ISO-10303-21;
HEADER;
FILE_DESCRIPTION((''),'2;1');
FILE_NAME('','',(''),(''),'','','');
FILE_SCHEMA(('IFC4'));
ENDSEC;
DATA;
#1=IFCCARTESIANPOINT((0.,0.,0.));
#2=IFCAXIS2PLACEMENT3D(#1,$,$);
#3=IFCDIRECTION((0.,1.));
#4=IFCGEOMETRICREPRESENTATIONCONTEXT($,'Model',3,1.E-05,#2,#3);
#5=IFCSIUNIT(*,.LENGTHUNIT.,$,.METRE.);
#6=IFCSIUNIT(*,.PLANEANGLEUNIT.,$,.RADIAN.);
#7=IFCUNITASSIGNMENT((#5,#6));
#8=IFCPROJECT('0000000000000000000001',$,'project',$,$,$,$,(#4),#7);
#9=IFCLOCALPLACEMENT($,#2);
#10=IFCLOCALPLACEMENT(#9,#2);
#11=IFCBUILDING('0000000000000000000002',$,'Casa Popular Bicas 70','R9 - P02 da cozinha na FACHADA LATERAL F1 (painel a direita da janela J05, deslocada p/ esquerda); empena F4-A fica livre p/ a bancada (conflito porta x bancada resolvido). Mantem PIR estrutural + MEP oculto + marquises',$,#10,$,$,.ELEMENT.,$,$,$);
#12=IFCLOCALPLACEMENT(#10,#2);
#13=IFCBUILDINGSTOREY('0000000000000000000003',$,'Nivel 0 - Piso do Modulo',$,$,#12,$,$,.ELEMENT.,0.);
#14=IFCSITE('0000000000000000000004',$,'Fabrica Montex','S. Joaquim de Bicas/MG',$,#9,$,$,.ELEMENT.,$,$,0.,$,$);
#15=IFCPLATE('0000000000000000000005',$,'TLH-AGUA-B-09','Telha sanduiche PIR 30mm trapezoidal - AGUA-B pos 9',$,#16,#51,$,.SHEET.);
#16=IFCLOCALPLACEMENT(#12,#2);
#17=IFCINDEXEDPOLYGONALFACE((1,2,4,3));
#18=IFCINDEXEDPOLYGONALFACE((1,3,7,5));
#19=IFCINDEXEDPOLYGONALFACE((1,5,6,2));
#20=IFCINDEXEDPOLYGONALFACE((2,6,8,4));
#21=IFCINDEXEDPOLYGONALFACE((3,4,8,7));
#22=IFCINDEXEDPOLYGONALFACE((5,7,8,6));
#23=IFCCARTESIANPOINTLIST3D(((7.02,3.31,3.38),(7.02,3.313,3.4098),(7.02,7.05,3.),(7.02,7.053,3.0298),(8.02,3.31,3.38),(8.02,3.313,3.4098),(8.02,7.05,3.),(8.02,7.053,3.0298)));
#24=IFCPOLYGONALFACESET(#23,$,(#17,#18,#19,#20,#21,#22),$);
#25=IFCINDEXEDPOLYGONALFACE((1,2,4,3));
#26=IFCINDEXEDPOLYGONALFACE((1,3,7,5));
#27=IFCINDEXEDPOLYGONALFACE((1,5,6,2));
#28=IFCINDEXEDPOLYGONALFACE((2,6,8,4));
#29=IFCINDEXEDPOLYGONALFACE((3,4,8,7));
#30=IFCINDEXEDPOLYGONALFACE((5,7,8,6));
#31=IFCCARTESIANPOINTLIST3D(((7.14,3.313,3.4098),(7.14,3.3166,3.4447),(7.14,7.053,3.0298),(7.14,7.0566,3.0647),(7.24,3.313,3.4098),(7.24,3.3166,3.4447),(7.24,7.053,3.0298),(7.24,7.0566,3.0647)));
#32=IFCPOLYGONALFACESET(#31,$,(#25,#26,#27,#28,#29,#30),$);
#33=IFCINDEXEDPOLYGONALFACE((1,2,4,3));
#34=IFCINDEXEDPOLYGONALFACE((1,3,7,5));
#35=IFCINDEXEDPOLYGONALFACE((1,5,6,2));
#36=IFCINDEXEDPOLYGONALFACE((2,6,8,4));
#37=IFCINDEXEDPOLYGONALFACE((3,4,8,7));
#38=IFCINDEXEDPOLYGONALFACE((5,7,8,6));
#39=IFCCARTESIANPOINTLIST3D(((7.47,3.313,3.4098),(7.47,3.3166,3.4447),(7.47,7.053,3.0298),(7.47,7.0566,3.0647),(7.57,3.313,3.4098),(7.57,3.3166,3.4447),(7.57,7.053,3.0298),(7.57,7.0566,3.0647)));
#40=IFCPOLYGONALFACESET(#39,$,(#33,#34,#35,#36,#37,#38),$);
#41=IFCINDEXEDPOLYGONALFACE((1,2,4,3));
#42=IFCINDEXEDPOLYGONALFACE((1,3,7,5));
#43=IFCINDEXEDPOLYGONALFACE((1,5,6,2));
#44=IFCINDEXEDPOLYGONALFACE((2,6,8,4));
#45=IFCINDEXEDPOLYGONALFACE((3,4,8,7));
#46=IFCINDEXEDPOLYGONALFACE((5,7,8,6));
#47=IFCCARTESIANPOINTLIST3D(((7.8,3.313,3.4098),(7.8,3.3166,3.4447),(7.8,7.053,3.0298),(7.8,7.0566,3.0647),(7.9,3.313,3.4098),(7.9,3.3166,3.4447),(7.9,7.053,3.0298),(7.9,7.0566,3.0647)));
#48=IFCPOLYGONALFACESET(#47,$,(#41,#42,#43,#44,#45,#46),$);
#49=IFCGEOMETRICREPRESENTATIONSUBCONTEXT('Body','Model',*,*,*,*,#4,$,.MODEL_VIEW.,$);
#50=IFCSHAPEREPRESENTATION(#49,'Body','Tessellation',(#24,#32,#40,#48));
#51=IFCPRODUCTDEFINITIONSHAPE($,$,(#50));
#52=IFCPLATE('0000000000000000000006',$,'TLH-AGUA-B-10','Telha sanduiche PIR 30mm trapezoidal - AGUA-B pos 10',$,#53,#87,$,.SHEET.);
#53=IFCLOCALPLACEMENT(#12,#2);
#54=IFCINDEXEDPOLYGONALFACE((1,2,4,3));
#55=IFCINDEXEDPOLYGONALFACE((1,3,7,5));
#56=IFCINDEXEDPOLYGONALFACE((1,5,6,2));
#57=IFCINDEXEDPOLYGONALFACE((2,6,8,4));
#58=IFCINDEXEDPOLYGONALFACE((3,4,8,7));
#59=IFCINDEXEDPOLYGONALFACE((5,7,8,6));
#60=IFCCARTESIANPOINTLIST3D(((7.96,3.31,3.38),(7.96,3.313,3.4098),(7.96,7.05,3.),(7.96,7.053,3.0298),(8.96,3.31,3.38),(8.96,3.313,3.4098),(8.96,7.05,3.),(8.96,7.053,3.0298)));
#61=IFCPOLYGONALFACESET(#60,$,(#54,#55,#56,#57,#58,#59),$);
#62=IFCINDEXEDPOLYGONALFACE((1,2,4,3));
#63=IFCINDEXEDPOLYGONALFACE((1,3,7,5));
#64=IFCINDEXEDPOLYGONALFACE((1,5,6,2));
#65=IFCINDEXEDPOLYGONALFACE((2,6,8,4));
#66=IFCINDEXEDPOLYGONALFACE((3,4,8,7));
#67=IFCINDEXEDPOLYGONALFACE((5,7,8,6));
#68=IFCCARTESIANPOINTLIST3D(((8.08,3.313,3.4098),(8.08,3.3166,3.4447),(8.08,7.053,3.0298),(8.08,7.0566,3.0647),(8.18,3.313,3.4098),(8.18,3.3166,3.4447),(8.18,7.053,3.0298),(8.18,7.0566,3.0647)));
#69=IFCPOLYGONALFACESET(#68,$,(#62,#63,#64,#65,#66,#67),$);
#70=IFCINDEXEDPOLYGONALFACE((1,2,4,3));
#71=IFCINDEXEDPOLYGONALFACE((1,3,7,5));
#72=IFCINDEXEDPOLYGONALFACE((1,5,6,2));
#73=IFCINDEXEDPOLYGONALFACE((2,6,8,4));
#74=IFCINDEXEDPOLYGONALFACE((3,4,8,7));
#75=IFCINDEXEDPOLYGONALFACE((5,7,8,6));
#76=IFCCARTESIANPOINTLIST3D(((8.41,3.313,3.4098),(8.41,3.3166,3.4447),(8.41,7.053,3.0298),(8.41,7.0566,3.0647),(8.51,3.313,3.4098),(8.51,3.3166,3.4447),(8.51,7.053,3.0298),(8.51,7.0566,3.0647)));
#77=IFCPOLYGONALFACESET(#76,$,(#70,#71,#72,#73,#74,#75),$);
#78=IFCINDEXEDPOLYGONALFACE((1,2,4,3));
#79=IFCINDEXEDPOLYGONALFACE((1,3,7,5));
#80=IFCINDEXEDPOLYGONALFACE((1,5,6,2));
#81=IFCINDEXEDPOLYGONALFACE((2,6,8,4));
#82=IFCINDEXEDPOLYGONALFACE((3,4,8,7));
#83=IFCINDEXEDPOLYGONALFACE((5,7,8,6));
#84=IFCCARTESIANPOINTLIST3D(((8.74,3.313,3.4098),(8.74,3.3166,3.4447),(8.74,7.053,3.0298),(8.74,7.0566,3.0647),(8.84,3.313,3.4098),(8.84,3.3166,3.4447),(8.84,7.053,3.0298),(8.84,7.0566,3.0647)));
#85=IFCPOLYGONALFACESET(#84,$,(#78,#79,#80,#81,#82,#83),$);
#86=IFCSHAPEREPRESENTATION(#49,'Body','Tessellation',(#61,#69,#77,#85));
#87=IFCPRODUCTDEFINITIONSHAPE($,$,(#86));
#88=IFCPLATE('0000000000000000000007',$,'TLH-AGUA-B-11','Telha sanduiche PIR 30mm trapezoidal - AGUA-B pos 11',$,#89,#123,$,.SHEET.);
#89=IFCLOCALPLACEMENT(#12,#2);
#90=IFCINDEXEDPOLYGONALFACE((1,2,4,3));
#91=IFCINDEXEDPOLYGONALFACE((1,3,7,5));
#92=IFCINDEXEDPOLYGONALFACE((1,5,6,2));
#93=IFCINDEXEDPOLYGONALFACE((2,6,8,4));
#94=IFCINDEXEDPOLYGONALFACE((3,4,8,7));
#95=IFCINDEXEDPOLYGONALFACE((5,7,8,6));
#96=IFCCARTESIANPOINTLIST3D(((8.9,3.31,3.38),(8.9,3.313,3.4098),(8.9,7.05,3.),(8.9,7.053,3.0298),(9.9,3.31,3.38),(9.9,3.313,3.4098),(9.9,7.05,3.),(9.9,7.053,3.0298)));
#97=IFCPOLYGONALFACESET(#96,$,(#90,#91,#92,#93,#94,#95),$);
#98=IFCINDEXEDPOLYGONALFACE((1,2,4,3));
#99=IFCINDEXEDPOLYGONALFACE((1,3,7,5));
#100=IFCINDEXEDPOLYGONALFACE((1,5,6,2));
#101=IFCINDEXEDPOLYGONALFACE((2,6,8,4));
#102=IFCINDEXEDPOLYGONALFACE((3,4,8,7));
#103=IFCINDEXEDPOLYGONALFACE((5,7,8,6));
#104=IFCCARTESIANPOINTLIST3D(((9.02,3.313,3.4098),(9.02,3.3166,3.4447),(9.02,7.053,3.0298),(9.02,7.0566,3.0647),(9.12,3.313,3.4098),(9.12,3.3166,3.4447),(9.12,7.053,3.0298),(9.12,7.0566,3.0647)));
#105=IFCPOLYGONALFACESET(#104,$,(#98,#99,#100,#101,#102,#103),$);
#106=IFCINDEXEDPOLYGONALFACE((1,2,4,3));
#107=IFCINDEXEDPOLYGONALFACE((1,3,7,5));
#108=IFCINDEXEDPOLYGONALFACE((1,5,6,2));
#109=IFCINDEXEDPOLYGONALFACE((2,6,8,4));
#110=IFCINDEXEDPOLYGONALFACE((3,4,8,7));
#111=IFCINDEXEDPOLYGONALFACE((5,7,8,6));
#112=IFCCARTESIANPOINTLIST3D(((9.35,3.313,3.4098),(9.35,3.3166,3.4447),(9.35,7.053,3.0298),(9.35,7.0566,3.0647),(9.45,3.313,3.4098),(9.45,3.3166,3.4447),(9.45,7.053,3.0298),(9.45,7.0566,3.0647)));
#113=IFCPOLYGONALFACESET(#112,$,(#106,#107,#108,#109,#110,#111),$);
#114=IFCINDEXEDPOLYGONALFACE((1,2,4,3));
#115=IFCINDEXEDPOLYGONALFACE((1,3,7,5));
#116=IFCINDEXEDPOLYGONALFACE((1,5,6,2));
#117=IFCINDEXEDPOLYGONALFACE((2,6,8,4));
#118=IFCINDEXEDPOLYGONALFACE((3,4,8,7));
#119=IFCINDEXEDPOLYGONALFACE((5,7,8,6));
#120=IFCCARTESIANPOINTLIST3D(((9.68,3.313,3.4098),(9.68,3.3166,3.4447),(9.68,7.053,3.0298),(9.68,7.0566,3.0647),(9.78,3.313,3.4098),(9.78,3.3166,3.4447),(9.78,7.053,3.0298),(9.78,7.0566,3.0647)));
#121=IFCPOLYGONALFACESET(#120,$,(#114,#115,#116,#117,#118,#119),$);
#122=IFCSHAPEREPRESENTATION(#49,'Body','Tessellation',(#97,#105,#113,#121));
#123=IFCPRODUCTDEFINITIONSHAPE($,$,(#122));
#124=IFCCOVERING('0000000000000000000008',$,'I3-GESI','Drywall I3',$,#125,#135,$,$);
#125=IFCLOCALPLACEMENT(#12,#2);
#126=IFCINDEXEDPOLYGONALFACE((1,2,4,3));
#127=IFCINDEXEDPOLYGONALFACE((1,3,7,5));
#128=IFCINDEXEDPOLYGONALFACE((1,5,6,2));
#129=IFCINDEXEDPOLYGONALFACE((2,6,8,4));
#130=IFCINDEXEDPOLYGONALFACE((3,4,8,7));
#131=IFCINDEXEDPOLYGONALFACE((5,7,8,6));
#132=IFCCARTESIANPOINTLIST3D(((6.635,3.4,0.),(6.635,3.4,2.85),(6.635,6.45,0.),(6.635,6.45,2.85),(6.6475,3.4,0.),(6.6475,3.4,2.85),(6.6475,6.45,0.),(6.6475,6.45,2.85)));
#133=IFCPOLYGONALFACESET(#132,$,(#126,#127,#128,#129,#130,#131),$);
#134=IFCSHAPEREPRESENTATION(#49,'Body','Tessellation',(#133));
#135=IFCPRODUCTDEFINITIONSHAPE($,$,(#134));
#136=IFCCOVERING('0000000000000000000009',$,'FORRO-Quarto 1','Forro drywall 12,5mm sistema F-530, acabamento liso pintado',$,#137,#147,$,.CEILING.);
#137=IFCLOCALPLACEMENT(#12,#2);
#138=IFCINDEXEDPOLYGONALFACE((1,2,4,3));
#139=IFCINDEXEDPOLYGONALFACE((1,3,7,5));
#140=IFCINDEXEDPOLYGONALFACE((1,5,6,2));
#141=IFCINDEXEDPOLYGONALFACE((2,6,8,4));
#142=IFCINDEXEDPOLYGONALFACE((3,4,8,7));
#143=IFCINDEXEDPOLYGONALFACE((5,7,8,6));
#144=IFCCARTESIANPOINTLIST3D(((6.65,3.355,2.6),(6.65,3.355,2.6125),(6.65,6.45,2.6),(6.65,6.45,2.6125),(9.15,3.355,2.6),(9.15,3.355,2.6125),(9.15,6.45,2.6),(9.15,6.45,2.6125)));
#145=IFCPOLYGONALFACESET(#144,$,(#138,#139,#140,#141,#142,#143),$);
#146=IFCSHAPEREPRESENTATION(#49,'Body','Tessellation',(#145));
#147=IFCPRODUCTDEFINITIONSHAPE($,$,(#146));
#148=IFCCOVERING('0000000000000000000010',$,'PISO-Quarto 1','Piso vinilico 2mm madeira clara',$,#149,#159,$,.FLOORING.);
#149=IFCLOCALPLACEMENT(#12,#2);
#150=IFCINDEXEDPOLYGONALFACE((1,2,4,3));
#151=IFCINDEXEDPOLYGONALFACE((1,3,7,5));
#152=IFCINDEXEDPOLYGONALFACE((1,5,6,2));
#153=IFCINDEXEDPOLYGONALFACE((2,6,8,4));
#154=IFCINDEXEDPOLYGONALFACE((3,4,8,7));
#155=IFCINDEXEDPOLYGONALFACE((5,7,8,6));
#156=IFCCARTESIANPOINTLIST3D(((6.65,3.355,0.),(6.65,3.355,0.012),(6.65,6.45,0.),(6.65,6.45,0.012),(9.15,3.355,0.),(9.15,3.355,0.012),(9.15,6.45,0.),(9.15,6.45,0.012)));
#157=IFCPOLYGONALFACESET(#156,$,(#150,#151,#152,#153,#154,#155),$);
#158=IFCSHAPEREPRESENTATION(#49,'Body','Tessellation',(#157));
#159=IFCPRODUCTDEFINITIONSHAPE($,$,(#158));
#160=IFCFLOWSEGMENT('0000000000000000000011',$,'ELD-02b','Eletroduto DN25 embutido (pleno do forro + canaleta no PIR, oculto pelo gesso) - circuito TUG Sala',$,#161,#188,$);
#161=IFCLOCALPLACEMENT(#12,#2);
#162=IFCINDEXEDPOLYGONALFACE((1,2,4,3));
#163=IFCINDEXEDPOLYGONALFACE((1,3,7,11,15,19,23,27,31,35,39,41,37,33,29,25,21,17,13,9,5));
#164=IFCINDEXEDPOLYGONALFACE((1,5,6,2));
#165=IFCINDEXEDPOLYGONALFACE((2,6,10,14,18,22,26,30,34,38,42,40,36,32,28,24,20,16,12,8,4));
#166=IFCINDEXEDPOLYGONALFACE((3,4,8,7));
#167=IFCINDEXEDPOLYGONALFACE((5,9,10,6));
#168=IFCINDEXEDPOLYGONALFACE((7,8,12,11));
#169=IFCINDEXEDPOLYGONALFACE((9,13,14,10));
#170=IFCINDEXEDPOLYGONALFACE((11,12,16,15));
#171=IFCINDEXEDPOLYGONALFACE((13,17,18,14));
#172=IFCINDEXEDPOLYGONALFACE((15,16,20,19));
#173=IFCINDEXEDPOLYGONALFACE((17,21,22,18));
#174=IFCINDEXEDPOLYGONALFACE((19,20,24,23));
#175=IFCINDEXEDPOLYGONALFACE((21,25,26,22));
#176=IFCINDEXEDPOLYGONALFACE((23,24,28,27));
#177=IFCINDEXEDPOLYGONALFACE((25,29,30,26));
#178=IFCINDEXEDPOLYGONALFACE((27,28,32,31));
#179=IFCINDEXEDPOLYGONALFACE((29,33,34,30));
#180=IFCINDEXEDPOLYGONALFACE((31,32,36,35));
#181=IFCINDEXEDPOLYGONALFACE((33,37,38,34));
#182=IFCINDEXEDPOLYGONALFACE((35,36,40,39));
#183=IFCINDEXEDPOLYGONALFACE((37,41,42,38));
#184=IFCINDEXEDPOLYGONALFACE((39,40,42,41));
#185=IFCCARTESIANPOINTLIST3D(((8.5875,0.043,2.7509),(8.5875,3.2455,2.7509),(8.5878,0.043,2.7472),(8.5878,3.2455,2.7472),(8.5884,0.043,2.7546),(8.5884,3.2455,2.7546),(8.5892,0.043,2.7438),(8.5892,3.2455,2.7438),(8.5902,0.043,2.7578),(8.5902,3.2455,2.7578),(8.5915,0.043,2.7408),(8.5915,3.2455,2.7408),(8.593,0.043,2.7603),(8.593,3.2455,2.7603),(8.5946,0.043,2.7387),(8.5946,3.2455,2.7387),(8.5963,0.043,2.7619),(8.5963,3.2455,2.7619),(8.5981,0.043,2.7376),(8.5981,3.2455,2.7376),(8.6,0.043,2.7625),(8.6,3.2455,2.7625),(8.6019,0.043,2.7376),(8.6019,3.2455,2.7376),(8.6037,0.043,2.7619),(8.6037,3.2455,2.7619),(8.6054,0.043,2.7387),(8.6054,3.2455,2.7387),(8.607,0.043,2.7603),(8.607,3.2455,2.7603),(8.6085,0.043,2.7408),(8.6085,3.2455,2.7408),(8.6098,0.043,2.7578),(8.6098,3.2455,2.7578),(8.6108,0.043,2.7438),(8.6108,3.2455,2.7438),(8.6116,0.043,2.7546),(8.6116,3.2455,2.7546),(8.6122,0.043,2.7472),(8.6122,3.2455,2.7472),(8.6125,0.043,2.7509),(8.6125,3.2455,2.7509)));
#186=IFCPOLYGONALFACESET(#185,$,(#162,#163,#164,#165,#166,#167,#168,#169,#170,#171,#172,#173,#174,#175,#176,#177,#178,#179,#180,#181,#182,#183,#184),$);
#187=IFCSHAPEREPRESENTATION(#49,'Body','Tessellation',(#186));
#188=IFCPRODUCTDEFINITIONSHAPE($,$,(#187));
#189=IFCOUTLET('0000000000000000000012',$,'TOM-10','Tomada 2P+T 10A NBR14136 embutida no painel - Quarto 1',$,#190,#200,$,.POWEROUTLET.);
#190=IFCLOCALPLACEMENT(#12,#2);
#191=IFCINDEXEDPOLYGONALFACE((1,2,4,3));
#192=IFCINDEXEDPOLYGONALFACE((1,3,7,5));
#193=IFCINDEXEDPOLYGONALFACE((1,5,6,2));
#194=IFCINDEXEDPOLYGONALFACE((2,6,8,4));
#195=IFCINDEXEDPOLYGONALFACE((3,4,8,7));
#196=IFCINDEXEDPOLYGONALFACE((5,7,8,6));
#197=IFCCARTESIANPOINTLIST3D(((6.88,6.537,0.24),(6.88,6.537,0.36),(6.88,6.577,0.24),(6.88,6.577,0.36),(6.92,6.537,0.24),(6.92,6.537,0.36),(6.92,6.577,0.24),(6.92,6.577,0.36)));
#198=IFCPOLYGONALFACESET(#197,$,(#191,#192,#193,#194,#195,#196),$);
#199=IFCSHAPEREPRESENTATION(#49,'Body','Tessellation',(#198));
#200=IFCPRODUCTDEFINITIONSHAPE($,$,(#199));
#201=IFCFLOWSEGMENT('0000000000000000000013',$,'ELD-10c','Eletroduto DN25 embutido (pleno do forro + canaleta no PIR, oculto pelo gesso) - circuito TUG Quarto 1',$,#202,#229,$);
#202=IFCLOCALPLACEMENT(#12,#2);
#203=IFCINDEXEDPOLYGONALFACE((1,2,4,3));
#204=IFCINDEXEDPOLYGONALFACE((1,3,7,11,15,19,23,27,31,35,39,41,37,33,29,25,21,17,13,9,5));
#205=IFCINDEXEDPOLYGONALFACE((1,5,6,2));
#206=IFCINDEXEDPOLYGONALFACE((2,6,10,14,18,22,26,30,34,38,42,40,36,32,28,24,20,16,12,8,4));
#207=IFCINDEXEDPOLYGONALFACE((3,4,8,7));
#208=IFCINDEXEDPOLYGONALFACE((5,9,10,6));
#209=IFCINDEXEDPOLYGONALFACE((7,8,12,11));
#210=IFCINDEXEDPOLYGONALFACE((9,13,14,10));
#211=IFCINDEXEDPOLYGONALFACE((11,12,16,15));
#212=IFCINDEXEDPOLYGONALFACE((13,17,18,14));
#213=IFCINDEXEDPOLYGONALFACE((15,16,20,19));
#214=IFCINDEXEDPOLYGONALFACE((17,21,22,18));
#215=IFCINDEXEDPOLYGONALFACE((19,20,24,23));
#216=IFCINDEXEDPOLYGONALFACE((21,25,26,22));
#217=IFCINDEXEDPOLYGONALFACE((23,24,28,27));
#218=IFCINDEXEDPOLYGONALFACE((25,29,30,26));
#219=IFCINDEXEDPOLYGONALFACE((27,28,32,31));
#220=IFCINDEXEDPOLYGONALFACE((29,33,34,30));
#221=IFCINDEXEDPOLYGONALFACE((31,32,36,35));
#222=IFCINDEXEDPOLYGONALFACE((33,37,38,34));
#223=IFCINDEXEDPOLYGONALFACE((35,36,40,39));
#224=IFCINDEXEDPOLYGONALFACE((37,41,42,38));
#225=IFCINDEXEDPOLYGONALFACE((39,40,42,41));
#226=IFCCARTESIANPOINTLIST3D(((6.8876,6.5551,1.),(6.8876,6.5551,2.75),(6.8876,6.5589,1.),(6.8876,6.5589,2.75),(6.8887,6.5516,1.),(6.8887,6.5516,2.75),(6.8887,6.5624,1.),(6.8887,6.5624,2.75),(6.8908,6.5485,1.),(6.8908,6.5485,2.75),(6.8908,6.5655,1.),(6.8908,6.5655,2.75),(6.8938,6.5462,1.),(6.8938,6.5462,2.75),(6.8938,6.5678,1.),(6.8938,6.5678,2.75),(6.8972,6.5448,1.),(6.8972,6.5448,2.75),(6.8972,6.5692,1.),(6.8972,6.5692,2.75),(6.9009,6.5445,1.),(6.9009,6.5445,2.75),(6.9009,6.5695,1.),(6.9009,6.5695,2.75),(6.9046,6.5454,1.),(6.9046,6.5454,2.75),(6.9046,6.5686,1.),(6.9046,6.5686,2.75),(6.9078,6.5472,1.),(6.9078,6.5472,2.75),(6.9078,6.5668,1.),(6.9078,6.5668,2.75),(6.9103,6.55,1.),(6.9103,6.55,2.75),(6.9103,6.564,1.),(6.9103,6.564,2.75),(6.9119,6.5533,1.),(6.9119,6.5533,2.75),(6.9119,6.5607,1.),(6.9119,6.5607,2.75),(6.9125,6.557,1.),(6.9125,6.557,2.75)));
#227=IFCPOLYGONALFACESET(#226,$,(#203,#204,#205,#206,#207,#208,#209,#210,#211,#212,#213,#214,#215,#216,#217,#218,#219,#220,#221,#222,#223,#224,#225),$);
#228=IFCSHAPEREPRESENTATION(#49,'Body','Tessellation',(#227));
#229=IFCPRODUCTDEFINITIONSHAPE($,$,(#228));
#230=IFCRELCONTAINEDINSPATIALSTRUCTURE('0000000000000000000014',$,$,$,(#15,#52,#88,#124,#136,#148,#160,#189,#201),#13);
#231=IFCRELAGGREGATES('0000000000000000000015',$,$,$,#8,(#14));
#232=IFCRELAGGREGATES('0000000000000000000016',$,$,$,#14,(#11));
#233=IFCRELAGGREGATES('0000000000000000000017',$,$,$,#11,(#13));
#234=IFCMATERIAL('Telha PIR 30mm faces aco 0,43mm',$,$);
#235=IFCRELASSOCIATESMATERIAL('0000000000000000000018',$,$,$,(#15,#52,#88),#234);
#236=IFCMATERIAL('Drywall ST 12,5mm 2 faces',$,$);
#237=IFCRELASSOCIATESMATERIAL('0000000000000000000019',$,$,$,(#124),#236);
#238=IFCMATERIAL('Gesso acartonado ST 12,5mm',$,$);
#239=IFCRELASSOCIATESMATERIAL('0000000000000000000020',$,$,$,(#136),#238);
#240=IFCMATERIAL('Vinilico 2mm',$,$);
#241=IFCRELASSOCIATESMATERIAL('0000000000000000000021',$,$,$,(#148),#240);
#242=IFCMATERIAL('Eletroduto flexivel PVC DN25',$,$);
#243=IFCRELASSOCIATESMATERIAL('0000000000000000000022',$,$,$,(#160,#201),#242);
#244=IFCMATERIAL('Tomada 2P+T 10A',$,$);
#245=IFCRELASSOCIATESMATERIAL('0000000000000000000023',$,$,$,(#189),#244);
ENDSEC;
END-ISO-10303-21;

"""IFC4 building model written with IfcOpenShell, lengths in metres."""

from ifc_helpers import new_model, si_unit, direction, frame, frame_2d, origin, origin_2d, place, context, subcontext, project, spatial, rectangle, circle, extrude, material, element, save


model = new_model("IFC4")

# Units and contexts
model_context = context("Model", 3, precision=1e-05, world=origin(), true_north=direction((0.0, 1.0)))
body_context = subcontext(model_context, "Body", "Model", "MODEL_VIEW")
ifc_project = project(units=[si_unit("LENGTHUNIT", "METRE"), si_unit("PLANEANGLEUNIT", "RADIAN")], contexts=[model_context])

# Site, building, storey
site_placement = place(None, origin())
site = spatial("IfcSite", under=ifc_project, at=site_placement, Name="Fabrica Montex", Description="S. Joaquim de Bicas/MG", CompositionType="ELEMENT", RefElevation=0.0)
building_placement = place(site_placement, origin())
building = spatial("IfcBuilding", under=site, at=building_placement, Name="Casa Popular Bicas 70", Description="R9 - P02 da cozinha na FACHADA LATERAL F1 (painel a direita da janela J05, deslocada p/ esquerda); empena F4-A fica livre p/ a bancada (conflito porta x bancada resolvido). Mantem PIR estrutural + MEP oculto + marquises", CompositionType="ELEMENT")
storey_placement = place(building_placement, origin())
storey = spatial("IfcBuildingStorey", under=building, at=storey_placement, Name="Nivel 0 - Piso do Modulo", CompositionType="ELEMENT", Elevation=0.0)

# Plates
ifc_material_1 = material(Name="Telha PIR 30mm faces aco 0,43mm")
for number, where, z_axis, x_axis, name, description in (
    (1, (7.02, 3.31, 3.38), (0.0, 0.101084, 0.994878), (1.0, 0.0, 0.0), "TLH-AGUA-B-09", "Telha sanduiche PIR 30mm trapezoidal - AGUA-B pos 9"),
    (2, (7.96, 3.31, 3.38), (0.0, 0.101084, 0.994878), (1.0, 0.0, 0.0), "TLH-AGUA-B-10", "Telha sanduiche PIR 30mm trapezoidal - AGUA-B pos 10"),
    (3, (8.9, 3.31, 3.38), (0.0, 0.101084, 0.994878), (1.0, 0.0, 0.0), "TLH-AGUA-B-11", "Telha sanduiche PIR 30mm trapezoidal - AGUA-B pos 11"),
):
    element("IfcPlate", number, at=place(storey_placement, frame(where, z_axis=z_axis, x_axis=x_axis)), inside=storey, material=ifc_material_1, Name=name, Description=description, PredefinedType="SHEET", context=body_context, shape_type="SweptSolid", body=[
        extrude(rectangle(XDim=1.0, YDim=3.7593, at=frame_2d((0.5, 1.8796))), origin(), (0.0, 0.0, 1.0), 0.03),
        extrude(rectangle(XDim=0.1, YDim=3.7593, at=frame_2d((0.17, 1.8796))), frame((0.0, 0.0, 0.03)), (0.0, 0.0, 1.0), 0.035),
        extrude(rectangle(XDim=0.1, YDim=3.7593, at=frame_2d((0.5, 1.8796))), frame((0.0, 0.0, 0.03)), (0.0, 0.0, 1.0), 0.035),
        extrude(rectangle(XDim=0.1, YDim=3.7593, at=frame_2d((0.83, 1.8796))), frame((0.0, 0.0, 0.03)), (0.0, 0.0, 1.0), 0.035),
    ])

# Coverings
ifc_material_2 = material(Name="Drywall ST 12,5mm 2 faces")
covering_1_placement = place(storey_placement, frame((6.6412, 3.4, 0.0), x_axis=(0.0, 1.0, 0.0)))
element("IfcCovering", 4, at=covering_1_placement, inside=storey, material=ifc_material_2, Name="I3-GESI", Description="Drywall I3", context=body_context, shape_type="SweptSolid", body=[
    extrude(rectangle(XDim=3.05, YDim=0.0125, at=frame_2d((1.525, 0.0))), origin(), (0.0, 0.0, 1.0), 2.85),
])
ifc_material_3 = material(Name="Gesso acartonado ST 12,5mm")
covering_2_placement = place(storey_placement, frame((6.65, 3.355, 2.6)))
element("IfcCovering", 5, at=covering_2_placement, inside=storey, material=ifc_material_3, Name="FORRO-Quarto 1", Description="Forro drywall 12,5mm sistema F-530, acabamento liso pintado", PredefinedType="CEILING", context=body_context, shape_type="SweptSolid", body=[
    extrude(rectangle(XDim=2.5, YDim=3.095, at=frame_2d((1.25, 1.5475))), origin(), (0.0, 0.0, 1.0), 0.0125),
])
ifc_material_4 = material(Name="Vinilico 2mm")
covering_3_placement = place(storey_placement, frame((6.65, 3.355, 0.0)))
element("IfcCovering", 6, at=covering_3_placement, inside=storey, material=ifc_material_4, Name="PISO-Quarto 1", Description="Piso vinilico 2mm madeira clara", PredefinedType="FLOORING", context=body_context, shape_type="SweptSolid", body=[
    extrude(rectangle(XDim=2.5, YDim=3.095, at=frame_2d((1.25, 1.5475))), origin(), (0.0, 0.0, 1.0), 0.012),
])

# Flow segment
ifc_material_5 = material(Name="Eletroduto flexivel PVC DN25")
flow_segment_1_placement = place(storey_placement, frame((8.6, 3.2455, 2.75), z_axis=(0.0, -1.0, 0.0), x_axis=(0.0, 0.0, 1.0)))
element("IfcFlowSegment", 7, at=flow_segment_1_placement, inside=storey, material=ifc_material_5, Name="ELD-02b", Description="Eletroduto DN25 embutido (pleno do forro + canaleta no PIR, oculto pelo gesso) - circuito TUG Sala", context=body_context, shape_type="SweptSolid", body=[
    extrude(circle(Radius=0.0125, at=origin_2d()), origin(), (0.0, 0.0, 1.0), 3.2025),
])

# Outlet
ifc_material_6 = material(Name="Tomada 2P+T 10A")
outlet_1_placement = place(storey_placement, frame((6.88, 6.537, 0.24)))
element("IfcOutlet", 8, at=outlet_1_placement, inside=storey, material=ifc_material_6, Name="TOM-10", Description="Tomada 2P+T 10A NBR14136 embutida no painel - Quarto 1", PredefinedType="POWEROUTLET", context=body_context, shape_type="SweptSolid", body=[
    extrude(rectangle(XDim=0.04, YDim=0.04, at=frame_2d((0.02, 0.02))), origin(), (0.0, 0.0, 1.0), 0.12),
])

# Flow segment
for number, where, z_axis, x_axis, name in (
    (9, (6.9, 6.557, 2.75), (0.0, 0.0, -1.0), (1.0, 0.0, 0.0), "ELD-10c"),
):
    element("IfcFlowSegment", number, at=place(storey_placement, frame(where, z_axis=z_axis, x_axis=x_axis)), inside=storey, material=ifc_material_5, Name=name, Description="Eletroduto DN25 embutido (pleno do forro + canaleta no PIR, oculto pelo gesso) - circuito TUG Quarto 1", context=body_context, shape_type="SweptSolid", body=[
        extrude(circle(Radius=0.0125, at=origin_2d()), origin(), (0.0, 0.0, 1.0), 1.75),
    ])

save(model, "model.ifc")
